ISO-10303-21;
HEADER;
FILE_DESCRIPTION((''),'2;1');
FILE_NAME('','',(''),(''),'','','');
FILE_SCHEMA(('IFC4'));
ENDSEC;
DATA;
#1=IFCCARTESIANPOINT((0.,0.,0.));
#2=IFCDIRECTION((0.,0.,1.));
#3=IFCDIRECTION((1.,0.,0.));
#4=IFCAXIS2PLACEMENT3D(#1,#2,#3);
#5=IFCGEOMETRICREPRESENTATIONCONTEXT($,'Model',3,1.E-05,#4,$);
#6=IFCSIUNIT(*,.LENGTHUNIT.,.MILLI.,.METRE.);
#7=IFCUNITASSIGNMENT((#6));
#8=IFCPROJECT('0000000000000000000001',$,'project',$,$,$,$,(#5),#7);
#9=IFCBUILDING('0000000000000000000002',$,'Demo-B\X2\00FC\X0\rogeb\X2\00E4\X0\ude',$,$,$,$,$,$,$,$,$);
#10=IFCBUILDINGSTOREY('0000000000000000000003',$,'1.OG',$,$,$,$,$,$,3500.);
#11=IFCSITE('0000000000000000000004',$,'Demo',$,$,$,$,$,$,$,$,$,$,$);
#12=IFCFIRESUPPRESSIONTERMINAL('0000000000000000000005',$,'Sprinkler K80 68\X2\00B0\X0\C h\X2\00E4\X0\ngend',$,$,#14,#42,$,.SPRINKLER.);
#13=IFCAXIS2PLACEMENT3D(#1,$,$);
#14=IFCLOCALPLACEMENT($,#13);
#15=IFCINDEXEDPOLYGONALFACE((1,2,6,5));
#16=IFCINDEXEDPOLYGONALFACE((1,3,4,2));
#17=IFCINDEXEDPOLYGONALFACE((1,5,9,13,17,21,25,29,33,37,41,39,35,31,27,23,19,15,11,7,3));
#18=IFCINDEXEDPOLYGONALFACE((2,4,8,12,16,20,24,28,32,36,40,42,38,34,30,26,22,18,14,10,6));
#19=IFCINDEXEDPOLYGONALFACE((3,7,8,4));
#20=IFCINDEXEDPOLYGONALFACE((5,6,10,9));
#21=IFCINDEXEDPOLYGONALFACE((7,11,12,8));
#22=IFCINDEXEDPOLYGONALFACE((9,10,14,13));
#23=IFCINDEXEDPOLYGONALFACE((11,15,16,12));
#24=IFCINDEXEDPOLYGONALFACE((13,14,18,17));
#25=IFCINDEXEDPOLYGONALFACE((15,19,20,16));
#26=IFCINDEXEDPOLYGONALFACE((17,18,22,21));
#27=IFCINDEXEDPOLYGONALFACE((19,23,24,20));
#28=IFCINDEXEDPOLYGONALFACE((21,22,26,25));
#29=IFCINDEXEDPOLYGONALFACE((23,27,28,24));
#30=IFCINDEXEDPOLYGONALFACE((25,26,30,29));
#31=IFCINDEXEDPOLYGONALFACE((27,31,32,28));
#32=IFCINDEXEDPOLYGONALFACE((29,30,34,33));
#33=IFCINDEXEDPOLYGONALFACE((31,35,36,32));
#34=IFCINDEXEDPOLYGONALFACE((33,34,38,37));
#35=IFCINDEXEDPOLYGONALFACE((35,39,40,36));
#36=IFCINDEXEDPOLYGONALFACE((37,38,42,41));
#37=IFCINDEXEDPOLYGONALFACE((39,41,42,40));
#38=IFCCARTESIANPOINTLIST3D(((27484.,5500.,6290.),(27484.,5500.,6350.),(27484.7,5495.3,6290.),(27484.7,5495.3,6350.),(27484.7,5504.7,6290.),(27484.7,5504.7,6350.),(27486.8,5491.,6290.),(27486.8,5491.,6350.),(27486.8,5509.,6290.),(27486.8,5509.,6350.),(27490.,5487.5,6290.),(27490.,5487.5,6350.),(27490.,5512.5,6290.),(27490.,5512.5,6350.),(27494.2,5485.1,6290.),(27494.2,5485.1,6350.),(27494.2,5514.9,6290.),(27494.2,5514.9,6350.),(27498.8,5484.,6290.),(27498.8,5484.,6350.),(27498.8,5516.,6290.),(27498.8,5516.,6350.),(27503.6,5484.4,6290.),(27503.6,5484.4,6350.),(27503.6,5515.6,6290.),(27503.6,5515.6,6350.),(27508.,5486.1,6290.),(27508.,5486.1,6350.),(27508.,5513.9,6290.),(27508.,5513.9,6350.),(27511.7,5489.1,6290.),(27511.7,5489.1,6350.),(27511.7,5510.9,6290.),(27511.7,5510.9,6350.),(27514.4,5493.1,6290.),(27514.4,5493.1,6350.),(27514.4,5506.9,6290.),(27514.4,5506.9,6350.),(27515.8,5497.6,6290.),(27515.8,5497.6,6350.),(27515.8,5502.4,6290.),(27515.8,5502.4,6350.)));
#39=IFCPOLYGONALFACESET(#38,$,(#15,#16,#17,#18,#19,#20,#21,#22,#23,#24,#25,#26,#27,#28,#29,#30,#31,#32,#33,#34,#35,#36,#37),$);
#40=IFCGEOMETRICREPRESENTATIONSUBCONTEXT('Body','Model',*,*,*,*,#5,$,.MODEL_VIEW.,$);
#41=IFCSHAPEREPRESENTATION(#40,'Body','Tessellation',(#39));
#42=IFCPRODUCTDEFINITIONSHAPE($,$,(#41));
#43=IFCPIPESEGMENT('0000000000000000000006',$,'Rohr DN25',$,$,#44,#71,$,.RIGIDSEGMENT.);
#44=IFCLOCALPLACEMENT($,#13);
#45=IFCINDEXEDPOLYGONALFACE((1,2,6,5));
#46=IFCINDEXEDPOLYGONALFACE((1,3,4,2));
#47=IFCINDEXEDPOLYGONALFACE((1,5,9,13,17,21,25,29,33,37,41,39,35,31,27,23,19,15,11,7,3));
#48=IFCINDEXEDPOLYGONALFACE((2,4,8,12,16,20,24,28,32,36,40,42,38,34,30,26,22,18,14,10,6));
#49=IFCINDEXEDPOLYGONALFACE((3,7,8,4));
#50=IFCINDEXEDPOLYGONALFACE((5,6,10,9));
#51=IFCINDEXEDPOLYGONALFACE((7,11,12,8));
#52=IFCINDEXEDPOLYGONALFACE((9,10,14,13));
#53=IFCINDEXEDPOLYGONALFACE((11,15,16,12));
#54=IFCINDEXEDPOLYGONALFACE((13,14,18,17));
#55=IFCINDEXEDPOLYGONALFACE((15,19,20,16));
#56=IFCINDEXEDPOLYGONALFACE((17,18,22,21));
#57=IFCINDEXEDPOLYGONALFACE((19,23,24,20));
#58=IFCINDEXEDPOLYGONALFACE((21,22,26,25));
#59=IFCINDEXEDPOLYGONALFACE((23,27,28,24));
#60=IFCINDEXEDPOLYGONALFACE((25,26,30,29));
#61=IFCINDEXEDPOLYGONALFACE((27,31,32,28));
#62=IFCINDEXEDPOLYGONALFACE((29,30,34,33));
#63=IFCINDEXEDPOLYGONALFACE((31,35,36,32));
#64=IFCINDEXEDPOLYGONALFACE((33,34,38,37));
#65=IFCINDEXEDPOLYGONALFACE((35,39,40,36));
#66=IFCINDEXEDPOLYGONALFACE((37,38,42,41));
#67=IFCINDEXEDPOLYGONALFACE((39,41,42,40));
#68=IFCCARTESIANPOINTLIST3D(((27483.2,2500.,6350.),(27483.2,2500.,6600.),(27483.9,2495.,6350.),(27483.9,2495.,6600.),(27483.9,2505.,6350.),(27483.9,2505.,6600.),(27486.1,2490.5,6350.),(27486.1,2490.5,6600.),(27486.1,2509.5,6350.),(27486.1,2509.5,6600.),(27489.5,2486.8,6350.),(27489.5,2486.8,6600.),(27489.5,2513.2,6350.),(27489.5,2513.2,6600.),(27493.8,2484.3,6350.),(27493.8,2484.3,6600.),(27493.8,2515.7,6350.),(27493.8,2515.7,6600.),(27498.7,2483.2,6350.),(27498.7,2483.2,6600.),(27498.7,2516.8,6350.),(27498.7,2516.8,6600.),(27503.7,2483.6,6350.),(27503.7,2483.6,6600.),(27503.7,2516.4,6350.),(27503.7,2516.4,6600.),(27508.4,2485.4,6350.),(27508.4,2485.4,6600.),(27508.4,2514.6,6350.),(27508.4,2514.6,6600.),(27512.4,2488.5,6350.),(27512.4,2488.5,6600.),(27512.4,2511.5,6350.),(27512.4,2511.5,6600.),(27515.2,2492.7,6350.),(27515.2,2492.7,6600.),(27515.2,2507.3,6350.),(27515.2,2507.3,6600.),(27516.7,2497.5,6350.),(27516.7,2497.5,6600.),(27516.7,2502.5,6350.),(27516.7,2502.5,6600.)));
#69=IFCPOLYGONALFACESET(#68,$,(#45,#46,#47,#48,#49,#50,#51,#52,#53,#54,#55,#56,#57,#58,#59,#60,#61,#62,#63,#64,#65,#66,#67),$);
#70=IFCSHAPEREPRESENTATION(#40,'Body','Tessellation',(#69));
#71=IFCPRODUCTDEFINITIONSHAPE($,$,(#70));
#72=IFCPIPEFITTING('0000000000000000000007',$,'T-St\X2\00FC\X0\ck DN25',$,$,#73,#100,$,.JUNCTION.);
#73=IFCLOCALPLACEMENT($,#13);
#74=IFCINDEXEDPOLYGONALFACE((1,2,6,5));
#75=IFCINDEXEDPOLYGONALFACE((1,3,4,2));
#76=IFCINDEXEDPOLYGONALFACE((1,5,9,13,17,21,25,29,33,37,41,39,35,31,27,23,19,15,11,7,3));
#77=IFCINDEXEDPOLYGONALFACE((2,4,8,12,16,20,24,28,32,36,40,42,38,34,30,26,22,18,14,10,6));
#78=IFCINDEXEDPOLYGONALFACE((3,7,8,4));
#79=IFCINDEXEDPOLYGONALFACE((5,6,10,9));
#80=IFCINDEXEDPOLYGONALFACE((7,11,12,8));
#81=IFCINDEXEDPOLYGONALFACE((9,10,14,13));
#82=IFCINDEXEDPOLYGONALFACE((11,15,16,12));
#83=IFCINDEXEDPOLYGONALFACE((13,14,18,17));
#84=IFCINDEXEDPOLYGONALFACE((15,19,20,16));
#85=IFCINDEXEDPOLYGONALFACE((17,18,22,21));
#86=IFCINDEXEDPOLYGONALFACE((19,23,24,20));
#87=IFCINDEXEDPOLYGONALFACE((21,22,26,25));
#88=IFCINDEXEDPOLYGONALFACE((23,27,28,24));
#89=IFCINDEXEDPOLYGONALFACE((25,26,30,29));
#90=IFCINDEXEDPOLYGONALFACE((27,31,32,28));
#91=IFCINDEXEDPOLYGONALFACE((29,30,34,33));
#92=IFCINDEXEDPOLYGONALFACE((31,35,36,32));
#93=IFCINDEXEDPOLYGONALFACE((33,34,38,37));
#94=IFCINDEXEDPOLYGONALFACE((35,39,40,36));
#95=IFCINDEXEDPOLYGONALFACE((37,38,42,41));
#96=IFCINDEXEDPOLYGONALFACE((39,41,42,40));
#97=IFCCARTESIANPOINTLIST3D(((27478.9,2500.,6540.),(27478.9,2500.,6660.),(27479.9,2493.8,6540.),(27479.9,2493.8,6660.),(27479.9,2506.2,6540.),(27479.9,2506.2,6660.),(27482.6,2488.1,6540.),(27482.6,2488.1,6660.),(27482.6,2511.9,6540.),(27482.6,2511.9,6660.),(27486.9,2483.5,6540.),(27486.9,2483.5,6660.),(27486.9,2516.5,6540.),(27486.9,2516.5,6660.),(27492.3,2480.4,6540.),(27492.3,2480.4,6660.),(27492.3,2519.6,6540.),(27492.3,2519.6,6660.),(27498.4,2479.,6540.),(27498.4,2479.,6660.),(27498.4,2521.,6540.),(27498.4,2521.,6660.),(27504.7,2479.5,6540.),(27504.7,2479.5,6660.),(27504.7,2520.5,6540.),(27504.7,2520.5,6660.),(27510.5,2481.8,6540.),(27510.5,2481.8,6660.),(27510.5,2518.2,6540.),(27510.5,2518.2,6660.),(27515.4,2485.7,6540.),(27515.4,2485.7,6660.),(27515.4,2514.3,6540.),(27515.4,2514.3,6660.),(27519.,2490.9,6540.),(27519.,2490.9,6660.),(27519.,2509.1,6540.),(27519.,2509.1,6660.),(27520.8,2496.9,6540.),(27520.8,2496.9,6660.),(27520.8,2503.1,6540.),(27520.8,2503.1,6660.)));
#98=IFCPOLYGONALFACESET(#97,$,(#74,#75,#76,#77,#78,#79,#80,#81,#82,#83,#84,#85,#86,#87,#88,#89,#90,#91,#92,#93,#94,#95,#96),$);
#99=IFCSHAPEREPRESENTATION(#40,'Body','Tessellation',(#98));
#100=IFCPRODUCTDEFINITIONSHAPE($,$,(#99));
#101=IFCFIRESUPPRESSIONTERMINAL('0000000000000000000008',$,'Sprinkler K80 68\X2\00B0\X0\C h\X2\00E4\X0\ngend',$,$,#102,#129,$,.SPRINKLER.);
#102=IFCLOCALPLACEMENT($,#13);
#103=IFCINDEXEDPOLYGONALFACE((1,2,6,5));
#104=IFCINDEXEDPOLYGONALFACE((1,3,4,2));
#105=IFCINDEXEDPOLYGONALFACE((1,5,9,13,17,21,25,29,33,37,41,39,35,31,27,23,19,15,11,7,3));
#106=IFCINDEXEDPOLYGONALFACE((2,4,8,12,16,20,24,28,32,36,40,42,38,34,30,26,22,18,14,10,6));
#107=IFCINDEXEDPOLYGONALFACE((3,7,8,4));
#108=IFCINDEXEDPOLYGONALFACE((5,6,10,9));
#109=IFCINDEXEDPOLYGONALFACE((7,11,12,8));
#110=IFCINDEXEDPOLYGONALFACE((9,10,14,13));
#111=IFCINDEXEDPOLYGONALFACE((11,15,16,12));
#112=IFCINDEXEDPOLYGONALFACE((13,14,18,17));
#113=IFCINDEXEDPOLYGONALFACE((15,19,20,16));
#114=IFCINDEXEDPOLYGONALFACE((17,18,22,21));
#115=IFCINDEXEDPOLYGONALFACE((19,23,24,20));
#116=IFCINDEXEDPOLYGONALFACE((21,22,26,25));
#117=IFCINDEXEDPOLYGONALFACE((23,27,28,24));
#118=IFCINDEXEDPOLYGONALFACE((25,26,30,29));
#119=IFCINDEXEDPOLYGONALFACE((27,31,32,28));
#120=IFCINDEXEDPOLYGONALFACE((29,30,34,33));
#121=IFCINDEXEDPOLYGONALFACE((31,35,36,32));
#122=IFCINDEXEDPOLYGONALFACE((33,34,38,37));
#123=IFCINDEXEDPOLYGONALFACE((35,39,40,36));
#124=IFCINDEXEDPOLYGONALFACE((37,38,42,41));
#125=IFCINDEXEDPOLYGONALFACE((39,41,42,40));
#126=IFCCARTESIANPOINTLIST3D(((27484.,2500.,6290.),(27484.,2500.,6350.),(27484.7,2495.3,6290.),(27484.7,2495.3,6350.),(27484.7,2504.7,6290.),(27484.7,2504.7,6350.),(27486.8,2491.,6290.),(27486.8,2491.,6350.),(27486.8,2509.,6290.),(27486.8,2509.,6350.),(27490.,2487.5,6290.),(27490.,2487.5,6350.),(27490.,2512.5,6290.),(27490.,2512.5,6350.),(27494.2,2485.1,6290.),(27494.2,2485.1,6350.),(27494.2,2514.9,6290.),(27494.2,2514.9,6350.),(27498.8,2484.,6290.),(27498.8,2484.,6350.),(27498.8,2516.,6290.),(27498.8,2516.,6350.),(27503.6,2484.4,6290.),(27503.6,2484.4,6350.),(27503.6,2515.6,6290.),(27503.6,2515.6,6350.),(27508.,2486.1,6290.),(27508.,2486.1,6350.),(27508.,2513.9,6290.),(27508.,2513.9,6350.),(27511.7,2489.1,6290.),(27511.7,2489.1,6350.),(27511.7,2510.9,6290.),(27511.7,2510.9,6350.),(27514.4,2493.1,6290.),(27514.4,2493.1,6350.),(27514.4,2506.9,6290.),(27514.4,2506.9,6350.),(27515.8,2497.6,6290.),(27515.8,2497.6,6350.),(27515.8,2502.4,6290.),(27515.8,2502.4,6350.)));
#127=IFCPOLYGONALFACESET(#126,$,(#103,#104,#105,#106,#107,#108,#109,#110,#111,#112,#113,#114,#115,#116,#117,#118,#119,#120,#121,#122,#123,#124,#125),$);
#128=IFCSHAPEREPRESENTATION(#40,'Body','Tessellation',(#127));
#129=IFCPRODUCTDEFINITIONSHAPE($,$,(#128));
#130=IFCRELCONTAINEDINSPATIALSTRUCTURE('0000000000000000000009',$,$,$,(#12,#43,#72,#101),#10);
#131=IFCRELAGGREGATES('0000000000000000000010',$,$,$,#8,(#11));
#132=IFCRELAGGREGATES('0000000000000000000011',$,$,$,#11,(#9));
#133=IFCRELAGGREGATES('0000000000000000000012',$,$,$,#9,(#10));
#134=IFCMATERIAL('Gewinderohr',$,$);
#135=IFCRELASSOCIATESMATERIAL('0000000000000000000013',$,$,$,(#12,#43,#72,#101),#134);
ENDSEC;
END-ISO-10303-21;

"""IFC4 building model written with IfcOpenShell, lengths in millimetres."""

from ifc_helpers import new_model, si_unit, frame, origin_with_axes, place, context, subcontext, project, spatial, circle, extrude, material, element, save


model = new_model("IFC4")

# Units and contexts
model_context = context("Model", 3, precision=1e-05, world=origin_with_axes())
body_context = subcontext(model_context, "Body", "Model", "MODEL_VIEW")
ifc_project = project(units=[si_unit("LENGTHUNIT", "METRE", prefix="MILLI")], contexts=[model_context])

# Site, building, storey
site = spatial("IfcSite", under=ifc_project, Name="Demo")
building = spatial("IfcBuilding", under=site, Name="Demo-Bürogebäude")
storey = spatial("IfcBuildingStorey", under=building, Name="1.OG", Elevation=3500.0)

# Shared definitions
ifc_material_1 = material(Name="Gewinderohr")

# Fire suppression terminal
fire_suppression_terminal_1_placement = place(None, frame((27500.0, 5500.0, 6350.0), z_axis=(0.0, 0.0, -1.0), x_axis=(-1.0, 0.0, 0.0)))
element("IfcFireSuppressionTerminal", 1, at=fire_suppression_terminal_1_placement, inside=storey, material=ifc_material_1, Name="Sprinkler K80 68°C hängend", PredefinedType="SPRINKLER", context=body_context, shape_type="SweptSolid", body=[
    extrude(circle(Radius=16.0), origin_with_axes(), (0.0, 0.0, 1.0), 60.0),
])

# Pipe segment
pipe_segment_1_placement = place(None, frame((27500.0, 2500.0, 6600.0), z_axis=(0.0, 0.0, -1.0), x_axis=(-1.0, 0.0, 0.0)))
element("IfcPipeSegment", 2, at=pipe_segment_1_placement, inside=storey, material=ifc_material_1, Name="Rohr DN25", PredefinedType="RIGIDSEGMENT", context=body_context, shape_type="SweptSolid", body=[
    extrude(circle(Radius=16.9), origin_with_axes(), (0.0, 0.0, 1.0), 250.0),
])

# Pipe fitting
pipe_fitting_1_placement = place(None, frame((27500.0, 2500.0, 6660.0), z_axis=(0.0, 0.0, -1.0), x_axis=(-1.0, 0.0, 0.0)))
element("IfcPipeFitting", 3, at=pipe_fitting_1_placement, inside=storey, material=ifc_material_1, Name="T-Stück DN25", PredefinedType="JUNCTION", context=body_context, shape_type="SweptSolid", body=[
    extrude(circle(Radius=21.1), origin_with_axes(), (0.0, 0.0, 1.0), 120.0),
])

# Fire suppression terminal
fire_suppression_terminal_2_placement = place(None, frame((27500.0, 2500.0, 6350.0), z_axis=(0.0, 0.0, -1.0), x_axis=(-1.0, 0.0, 0.0)))
element("IfcFireSuppressionTerminal", 4, at=fire_suppression_terminal_2_placement, inside=storey, material=ifc_material_1, Name="Sprinkler K80 68°C hängend", PredefinedType="SPRINKLER", context=body_context, shape_type="SweptSolid", body=[
    extrude(circle(Radius=16.0), origin_with_axes(), (0.0, 0.0, 1.0), 60.0),
])

save(model, "model.ifc")
